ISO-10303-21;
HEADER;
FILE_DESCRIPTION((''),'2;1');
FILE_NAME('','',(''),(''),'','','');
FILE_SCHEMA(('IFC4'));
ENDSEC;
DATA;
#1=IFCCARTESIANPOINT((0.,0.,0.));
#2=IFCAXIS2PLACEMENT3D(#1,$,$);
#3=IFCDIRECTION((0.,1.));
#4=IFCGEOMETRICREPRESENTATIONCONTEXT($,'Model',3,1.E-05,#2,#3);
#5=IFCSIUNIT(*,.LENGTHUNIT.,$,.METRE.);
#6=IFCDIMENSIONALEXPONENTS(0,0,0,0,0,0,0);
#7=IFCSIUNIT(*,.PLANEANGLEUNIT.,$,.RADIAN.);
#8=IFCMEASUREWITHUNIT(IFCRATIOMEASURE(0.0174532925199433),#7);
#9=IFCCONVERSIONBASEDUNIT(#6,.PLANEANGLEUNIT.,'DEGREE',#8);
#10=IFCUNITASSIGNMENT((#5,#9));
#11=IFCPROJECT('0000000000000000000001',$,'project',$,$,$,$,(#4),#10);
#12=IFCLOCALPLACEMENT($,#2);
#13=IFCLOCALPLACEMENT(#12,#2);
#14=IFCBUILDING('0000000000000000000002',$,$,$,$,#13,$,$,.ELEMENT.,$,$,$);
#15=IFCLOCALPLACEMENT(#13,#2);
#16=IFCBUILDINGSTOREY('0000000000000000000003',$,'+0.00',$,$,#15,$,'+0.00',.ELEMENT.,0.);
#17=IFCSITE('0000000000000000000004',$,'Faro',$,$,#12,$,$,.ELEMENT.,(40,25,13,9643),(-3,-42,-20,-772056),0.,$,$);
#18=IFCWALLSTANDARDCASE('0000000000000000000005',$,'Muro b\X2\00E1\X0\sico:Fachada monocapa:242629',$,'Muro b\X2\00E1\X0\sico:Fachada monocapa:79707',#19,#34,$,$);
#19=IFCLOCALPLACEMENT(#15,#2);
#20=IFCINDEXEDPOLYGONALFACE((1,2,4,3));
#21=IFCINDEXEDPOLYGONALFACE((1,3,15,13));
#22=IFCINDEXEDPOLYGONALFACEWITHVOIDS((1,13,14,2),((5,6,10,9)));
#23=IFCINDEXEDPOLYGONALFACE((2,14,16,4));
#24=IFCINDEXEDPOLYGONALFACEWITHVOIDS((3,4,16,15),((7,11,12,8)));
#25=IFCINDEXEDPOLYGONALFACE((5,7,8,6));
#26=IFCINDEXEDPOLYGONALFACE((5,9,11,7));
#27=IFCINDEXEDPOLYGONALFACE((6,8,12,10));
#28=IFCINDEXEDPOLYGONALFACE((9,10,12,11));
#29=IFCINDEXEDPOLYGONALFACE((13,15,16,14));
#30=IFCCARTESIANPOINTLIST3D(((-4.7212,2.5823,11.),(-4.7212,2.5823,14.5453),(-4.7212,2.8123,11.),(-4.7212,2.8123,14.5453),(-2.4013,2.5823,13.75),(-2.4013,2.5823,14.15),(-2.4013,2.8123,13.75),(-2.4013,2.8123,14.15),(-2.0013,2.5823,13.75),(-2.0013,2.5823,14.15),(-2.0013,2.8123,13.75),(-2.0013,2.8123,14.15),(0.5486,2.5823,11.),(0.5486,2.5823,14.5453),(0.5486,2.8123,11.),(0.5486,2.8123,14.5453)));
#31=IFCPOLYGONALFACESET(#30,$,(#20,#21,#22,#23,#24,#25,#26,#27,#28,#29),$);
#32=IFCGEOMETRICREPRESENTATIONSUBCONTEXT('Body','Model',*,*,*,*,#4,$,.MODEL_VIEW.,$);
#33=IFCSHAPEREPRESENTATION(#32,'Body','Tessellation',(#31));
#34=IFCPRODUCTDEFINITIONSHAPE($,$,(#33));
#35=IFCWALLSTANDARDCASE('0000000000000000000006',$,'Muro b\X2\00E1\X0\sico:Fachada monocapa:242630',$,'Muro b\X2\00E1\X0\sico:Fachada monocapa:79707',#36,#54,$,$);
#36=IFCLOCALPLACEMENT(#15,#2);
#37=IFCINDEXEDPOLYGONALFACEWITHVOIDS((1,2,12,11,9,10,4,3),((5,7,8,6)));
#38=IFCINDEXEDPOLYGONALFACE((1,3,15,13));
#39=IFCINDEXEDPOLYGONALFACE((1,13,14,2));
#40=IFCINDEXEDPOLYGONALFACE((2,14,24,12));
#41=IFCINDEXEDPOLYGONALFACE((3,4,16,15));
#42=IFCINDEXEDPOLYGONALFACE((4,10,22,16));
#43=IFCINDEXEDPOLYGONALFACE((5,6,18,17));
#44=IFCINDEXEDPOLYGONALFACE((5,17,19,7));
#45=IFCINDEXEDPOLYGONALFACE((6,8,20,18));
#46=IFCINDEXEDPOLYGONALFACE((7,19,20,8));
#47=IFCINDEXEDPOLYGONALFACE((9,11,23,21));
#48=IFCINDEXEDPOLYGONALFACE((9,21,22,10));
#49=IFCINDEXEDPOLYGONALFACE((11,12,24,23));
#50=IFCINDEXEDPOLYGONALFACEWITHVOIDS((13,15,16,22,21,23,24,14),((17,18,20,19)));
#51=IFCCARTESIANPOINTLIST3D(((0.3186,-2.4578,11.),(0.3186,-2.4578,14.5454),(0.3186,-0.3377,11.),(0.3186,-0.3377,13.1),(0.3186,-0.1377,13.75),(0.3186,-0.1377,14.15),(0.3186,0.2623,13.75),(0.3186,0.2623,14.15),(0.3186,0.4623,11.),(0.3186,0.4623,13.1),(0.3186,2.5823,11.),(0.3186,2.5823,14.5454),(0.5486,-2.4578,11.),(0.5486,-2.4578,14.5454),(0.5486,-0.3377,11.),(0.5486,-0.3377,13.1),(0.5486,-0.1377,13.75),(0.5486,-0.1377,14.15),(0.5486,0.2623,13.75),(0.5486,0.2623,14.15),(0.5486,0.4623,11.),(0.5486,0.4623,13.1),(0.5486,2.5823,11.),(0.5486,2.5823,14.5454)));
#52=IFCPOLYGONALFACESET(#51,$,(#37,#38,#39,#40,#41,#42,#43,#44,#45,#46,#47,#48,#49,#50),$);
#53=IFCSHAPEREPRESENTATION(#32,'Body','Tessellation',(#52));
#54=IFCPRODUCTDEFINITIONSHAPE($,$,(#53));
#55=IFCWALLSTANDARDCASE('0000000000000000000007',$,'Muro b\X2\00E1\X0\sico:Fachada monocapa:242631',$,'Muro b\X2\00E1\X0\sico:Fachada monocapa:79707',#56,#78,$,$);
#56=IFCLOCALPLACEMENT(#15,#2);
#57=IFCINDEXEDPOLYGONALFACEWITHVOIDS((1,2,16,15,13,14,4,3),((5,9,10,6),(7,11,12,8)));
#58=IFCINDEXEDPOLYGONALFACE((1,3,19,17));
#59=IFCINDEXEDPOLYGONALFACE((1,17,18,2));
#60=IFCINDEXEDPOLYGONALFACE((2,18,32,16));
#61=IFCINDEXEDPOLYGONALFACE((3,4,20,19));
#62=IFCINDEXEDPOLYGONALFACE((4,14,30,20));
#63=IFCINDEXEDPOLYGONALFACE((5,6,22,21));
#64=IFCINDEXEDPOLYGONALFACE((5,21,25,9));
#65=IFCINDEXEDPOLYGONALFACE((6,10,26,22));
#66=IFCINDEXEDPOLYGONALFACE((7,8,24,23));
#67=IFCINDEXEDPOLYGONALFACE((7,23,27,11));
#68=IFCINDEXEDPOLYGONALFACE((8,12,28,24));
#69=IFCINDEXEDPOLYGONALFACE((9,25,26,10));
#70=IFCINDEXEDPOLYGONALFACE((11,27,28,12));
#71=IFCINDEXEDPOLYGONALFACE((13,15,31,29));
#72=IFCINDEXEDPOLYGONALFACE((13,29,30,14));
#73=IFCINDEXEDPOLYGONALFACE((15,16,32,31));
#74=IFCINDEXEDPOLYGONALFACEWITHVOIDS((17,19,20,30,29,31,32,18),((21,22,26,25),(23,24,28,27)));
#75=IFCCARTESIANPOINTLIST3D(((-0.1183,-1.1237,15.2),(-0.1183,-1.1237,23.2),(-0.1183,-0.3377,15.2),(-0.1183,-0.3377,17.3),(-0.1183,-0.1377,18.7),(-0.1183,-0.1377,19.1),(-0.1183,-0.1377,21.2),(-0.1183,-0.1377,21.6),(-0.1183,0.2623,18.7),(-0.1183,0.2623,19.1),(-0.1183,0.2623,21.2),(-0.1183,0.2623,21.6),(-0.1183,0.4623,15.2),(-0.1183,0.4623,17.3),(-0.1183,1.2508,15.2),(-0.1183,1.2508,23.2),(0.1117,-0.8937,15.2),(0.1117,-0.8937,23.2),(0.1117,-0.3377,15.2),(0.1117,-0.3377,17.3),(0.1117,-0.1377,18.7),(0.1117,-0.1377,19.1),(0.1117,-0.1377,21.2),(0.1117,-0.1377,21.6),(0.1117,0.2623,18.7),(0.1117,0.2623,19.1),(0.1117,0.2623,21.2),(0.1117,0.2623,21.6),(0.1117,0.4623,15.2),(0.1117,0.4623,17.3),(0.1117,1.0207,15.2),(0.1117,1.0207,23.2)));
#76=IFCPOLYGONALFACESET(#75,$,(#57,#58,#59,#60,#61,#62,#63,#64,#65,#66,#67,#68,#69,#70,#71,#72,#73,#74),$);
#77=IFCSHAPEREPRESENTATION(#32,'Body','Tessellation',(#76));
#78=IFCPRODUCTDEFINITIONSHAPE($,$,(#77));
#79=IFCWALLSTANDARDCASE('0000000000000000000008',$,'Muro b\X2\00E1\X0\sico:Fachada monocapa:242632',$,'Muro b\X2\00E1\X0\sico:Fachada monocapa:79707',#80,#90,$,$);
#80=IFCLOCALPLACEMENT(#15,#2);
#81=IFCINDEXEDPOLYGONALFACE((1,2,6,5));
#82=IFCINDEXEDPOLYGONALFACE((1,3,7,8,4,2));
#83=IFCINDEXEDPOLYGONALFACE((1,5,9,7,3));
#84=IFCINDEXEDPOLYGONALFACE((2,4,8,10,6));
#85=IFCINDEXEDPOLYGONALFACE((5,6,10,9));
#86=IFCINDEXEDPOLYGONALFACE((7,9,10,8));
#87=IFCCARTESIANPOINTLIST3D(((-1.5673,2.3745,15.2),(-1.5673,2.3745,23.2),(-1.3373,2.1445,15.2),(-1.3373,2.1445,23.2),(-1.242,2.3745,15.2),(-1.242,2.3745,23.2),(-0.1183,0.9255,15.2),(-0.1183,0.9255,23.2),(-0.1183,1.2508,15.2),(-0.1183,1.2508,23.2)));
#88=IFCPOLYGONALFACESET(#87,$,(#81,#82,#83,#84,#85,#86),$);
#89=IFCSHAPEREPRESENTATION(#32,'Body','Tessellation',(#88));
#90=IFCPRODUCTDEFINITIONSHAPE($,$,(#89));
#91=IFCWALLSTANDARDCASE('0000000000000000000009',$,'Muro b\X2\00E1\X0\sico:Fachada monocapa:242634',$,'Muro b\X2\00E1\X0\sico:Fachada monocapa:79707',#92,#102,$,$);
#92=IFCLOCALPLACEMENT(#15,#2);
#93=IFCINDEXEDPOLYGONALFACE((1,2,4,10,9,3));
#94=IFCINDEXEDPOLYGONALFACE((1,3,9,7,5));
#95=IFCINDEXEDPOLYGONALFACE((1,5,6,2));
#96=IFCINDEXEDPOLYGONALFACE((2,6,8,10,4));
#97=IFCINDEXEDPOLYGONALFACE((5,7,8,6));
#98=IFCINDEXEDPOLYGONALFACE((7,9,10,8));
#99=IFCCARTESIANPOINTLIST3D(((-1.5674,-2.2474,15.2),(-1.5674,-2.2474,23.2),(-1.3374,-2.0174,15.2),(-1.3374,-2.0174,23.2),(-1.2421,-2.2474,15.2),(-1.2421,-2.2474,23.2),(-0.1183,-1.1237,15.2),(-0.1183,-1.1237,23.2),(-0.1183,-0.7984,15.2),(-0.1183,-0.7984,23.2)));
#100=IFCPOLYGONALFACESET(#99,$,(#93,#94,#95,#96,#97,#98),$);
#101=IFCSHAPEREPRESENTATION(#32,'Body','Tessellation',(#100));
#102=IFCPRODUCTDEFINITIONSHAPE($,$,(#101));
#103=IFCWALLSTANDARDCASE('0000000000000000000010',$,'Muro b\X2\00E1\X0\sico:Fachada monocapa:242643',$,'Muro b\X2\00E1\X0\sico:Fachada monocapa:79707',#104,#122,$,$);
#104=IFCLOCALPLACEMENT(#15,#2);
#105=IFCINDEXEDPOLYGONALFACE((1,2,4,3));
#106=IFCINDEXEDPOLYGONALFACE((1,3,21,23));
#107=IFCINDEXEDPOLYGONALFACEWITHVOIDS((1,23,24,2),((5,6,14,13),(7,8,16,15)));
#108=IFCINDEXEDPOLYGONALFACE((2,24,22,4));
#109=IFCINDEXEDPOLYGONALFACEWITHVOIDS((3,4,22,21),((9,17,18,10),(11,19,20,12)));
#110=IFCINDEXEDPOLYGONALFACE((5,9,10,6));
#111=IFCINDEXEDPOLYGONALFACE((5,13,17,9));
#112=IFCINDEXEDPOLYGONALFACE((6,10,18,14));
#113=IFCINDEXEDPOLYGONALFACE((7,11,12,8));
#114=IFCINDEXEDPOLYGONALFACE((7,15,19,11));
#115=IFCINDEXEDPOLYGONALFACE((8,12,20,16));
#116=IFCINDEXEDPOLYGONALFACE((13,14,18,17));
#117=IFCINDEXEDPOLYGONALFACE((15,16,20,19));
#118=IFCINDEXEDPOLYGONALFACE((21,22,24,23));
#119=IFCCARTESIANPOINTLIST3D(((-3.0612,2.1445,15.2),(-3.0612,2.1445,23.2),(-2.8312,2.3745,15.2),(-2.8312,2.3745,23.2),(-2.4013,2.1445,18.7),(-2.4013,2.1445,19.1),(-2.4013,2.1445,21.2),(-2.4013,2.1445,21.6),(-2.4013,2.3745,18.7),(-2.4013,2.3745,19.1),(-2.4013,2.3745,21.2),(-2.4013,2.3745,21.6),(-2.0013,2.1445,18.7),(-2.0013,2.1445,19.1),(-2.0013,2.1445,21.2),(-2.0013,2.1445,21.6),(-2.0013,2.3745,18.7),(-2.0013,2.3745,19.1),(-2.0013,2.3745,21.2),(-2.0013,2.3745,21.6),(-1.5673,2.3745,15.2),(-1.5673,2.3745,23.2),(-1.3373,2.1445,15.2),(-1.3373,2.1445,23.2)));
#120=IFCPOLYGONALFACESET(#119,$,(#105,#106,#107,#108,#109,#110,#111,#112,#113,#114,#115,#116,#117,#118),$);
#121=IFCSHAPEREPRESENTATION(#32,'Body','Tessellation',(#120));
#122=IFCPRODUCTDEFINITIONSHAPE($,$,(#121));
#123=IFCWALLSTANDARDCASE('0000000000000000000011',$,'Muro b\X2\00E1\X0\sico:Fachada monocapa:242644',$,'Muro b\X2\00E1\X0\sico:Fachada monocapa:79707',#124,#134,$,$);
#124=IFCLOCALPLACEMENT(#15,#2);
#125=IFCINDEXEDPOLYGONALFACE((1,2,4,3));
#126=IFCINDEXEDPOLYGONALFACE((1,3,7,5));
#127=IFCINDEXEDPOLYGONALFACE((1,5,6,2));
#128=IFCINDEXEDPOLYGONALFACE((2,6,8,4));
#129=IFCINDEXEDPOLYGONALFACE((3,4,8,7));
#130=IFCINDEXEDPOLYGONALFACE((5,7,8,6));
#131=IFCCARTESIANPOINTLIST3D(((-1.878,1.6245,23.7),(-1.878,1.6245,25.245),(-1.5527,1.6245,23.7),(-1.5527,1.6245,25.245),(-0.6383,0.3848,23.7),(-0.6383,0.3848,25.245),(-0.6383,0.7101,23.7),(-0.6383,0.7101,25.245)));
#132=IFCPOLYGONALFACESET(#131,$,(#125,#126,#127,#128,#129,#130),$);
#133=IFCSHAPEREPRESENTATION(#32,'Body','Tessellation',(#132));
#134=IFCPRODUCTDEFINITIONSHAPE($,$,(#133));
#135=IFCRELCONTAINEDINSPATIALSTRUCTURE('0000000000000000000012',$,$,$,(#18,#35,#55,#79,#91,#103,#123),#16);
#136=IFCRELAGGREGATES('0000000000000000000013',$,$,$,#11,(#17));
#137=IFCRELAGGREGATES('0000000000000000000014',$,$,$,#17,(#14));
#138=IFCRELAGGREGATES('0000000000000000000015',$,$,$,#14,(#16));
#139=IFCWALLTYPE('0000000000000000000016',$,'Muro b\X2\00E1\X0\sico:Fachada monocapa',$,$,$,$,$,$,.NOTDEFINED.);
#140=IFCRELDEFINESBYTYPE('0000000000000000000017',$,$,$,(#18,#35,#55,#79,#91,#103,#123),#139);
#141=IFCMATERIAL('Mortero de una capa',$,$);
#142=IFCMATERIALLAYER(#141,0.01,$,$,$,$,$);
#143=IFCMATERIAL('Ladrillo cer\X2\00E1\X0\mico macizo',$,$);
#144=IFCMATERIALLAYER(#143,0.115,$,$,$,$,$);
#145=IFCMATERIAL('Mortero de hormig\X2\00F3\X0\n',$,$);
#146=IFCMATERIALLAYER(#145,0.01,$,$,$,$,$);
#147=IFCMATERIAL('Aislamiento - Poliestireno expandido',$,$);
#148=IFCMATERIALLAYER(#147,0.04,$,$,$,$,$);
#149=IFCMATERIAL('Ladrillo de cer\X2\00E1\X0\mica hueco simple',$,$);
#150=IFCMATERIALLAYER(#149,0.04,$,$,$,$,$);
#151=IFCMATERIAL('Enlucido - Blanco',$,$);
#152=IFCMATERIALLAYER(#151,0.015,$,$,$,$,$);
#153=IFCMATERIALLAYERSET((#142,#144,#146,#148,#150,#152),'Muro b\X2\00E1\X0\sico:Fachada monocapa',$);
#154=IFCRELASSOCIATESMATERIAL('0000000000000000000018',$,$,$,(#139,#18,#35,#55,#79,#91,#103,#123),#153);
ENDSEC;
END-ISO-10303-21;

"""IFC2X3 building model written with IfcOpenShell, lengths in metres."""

from ifc_helpers import new_model, entity, si_unit, converted_unit, direction, frame, frame_2d, origin, place, context, subcontext, project, spatial, polyline, rectangle, outline, extrude, clip, bounded_halfspace, material, layer, layer_set, layer_usage, type_object, element, save


model = new_model("IFC2X3")

# Units and contexts
model_context = context("Model", 3, precision=1e-05, world=origin(), true_north=direction((0.0, 1.0)))
body_context = subcontext(model_context, "Body", "Model", "MODEL_VIEW")
ifc_project = project(units=[si_unit("LENGTHUNIT", "METRE"), converted_unit("PLANEANGLEUNIT", "DEGREE", entity("IfcRatioMeasure", 0.0174532925199433), si_unit("PLANEANGLEUNIT", "RADIAN"), dimensions=[0, 0, 0, 0, 0, 0, 0])], contexts=[model_context])

# Site, building, storey
site_placement = place(None, origin())
site = spatial("IfcSite", under=ifc_project, at=site_placement, Name="Faro", CompositionType="ELEMENT", RefLatitude=(40, 25, 13, 9643), RefLongitude=(-3, -42, -20, -772056), RefElevation=0.0)
building_placement = place(site_placement, origin())
building = spatial("IfcBuilding", under=site, at=building_placement, CompositionType="ELEMENT")
storey_placement = place(building_placement, origin())
storey = spatial("IfcBuildingStorey", under=building, at=storey_placement, Name="+0.00", LongName="+0.00", CompositionType="ELEMENT", Elevation=0.0)

# Wall, opening
ifc_material_1 = material(Name="Mortero de una capa")
ifc_layer_1 = layer(ifc_material_1, 0.01)
ifc_material_2 = material(Name="Ladrillo cerámico macizo")
ifc_layer_2 = layer(ifc_material_2, 0.115)
ifc_material_3 = material(Name="Mortero de hormigón")
ifc_layer_3 = layer(ifc_material_3, 0.01)
ifc_material_4 = material(Name="Aislamiento - Poliestireno expandido")
ifc_layer_4 = layer(ifc_material_4, 0.04)
ifc_material_5 = material(Name="Ladrillo de cerámica hueco simple")
ifc_layer_5 = layer(ifc_material_5, 0.04)
ifc_material_6 = material(Name="Enlucido - Blanco")
ifc_layer_6 = layer(ifc_material_6, 0.015)
ifc_layer_set = layer_set([ifc_layer_1, ifc_layer_2, ifc_layer_3, ifc_layer_4, ifc_layer_5, ifc_layer_6], Name="Muro básico:Fachada monocapa")
ifc_layer_usage_1 = layer_usage(ifc_layer_set, "AXIS2", "POSITIVE", -0.115)
wall_type = type_object("IfcWallType", Name="Muro básico:Fachada monocapa", PredefinedType="NOTDEFINED", material=ifc_layer_set)
wall_1_placement = place(storey_placement, frame((0.5486, 2.6973, 11.0), z_axis=(0.0, 0.0, 1.0), x_axis=(-1.0, 0.0, 0.0)))
wall_1 = element("IfcWallStandardCase", 1, at=wall_1_placement, inside=storey, type_object=wall_type, material=ifc_layer_usage_1, Name="Muro básico:Fachada monocapa:242629", ObjectType="Muro básico:Fachada monocapa:79707", context=body_context, shape_type="SweptSolid", body=[
    extrude(rectangle(XDim=5.2698, YDim=0.23, at=frame_2d((2.6349, 0.0), x_axis=(-1.0, 0.0))), origin(), (0.0, 0.0, 1.0), 3.5453),
])
opening_1_placement = place(wall_1_placement, frame((2.9499, 0.115, 2.75)))
element("IfcOpeningElement", 2, at=opening_1_placement, cuts=wall_1, ObjectType="Opening", context=body_context, shape_type="SweptSolid", body=[
    extrude(rectangle(XDim=0.4, YDim=0.4, at=frame_2d((0.2, 0.2), x_axis=(1.0, 0.0))), frame((0.0, 0.0, 0.0), z_axis=(0.0, -1.0, 0.0), x_axis=(0.0, 0.0, 1.0)), (0.0, 0.0, 1.0), 0.23),
])

# Walls, openings
ifc_layer_usage_2 = layer_usage(ifc_layer_set, "AXIS2", "POSITIVE", -0.115)
wall_2_placement = place(storey_placement, frame((0.4336, -2.4578, 11.0), z_axis=(0.0, 0.0, 1.0), x_axis=(0.0, 1.0, 0.0)))
wall_2 = element("IfcWallStandardCase", 3, at=wall_2_placement, inside=storey, type_object=wall_type, material=ifc_layer_usage_2, Name="Muro básico:Fachada monocapa:242630", ObjectType="Muro básico:Fachada monocapa:79707", context=body_context, shape_type="SweptSolid", body=[
    extrude(rectangle(XDim=5.0401, YDim=0.23, at=frame_2d((2.5201, 0.0), x_axis=(-1.0, 0.0))), origin(), (0.0, 0.0, 1.0), 3.5454),
])
opening_2_placement = place(wall_2_placement, frame((2.9201, 0.115, 0.0)))
element("IfcOpeningElement", 4, at=opening_2_placement, cuts=wall_2, ObjectType="Opening", context=body_context, shape_type="SweptSolid", body=[
    extrude(rectangle(XDim=2.1, YDim=0.8, at=frame_2d((1.05, 0.4), x_axis=(1.0, 0.0))), frame((0.0, 0.0, 0.0), z_axis=(0.0, -1.0, 0.0), x_axis=(0.0, 0.0, 1.0)), (0.0, 0.0, 1.0), 0.23),
])
opening_3_placement = place(wall_2_placement, frame((2.7201, 0.115, 2.75)))
element("IfcOpeningElement", 5, at=opening_3_placement, cuts=wall_2, ObjectType="Opening", context=body_context, shape_type="SweptSolid", body=[
    extrude(rectangle(XDim=0.4, YDim=0.4, at=frame_2d((0.2, 0.2), x_axis=(1.0, 0.0))), frame((0.0, 0.0, 0.0), z_axis=(0.0, -1.0, 0.0), x_axis=(0.0, 0.0, 1.0)), (0.0, 0.0, 1.0), 0.23),
])
ifc_layer_usage_3 = layer_usage(ifc_layer_set, "AXIS2", "POSITIVE", -0.115)
wall_3_placement = place(storey_placement, frame((-0.0033, -1.1237, 15.2), z_axis=(0.0, 0.0, 1.0), x_axis=(0.0, 1.0, 0.0)))
wall_3 = element("IfcWallStandardCase", 6, at=wall_3_placement, inside=storey, type_object=wall_type, material=ifc_layer_usage_3, Name="Muro básico:Fachada monocapa:242631", ObjectType="Muro básico:Fachada monocapa:79707", context=body_context, shape_type="SweptSolid", body=[
    extrude(outline(polyline([(0.23, -0.115), (2.1444, -0.115), (2.3744, 0.115), (2.0492, 0.115), (0.3253, 0.115), (0.0, 0.115), (0.23, -0.115)])), origin(), (0.0, 0.0, 1.0), 8.0),
])
opening_4_placement = place(wall_3_placement, frame((1.586, 0.115, 0.0)))
element("IfcOpeningElement", 7, at=opening_4_placement, cuts=wall_3, ObjectType="Opening", context=body_context, shape_type="SweptSolid", body=[
    extrude(rectangle(XDim=2.1, YDim=0.8, at=frame_2d((1.05, 0.4), x_axis=(1.0, 0.0))), frame((0.0, 0.0, 0.0), z_axis=(0.0, -1.0, 0.0), x_axis=(0.0, 0.0, 1.0)), (0.0, 0.0, 1.0), 0.23),
])
opening_5_placement = place(wall_3_placement, frame((1.386, 0.115, 3.5)))
element("IfcOpeningElement", 8, at=opening_5_placement, cuts=wall_3, ObjectType="Opening", context=body_context, shape_type="SweptSolid", body=[
    extrude(rectangle(XDim=0.4, YDim=0.4, at=frame_2d((0.2, 0.2), x_axis=(1.0, 0.0))), frame((0.0, 0.0, 0.0), z_axis=(0.0, -1.0, 0.0), x_axis=(0.0, 0.0, 1.0)), (0.0, 0.0, 1.0), 0.23),
])
opening_6_placement = place(wall_3_placement, frame((1.386, 0.115, 6.0)))
element("IfcOpeningElement", 9, at=opening_6_placement, cuts=wall_3, ObjectType="Opening", context=body_context, shape_type="SweptSolid", body=[
    extrude(rectangle(XDim=0.4, YDim=0.4, at=frame_2d((0.2, 0.2), x_axis=(1.0, 0.0))), frame((0.0, 0.0, 0.0), z_axis=(0.0, -1.0, 0.0), x_axis=(0.0, 0.0, 1.0)), (0.0, 0.0, 1.0), 0.23),
])

# Walls
ifc_layer_usage_4 = layer_usage(ifc_layer_set, "AXIS2", "POSITIVE", -0.115)
wall_4_placement = place(storey_placement, frame((-0.037, 1.0068, 15.2), z_axis=(0.0, 0.0, 1.0), x_axis=(-0.707093, 0.707121, 0.0)))
element("IfcWallStandardCase", 10, at=wall_4_placement, inside=storey, type_object=wall_type, material=ifc_layer_usage_4, Name="Muro básico:Fachada monocapa:242632", ObjectType="Muro básico:Fachada monocapa:79707", context=body_context, shape_type="SweptSolid", body=[
    extrude(outline(polyline([(1.8192, -0.115), (2.0492, 0.115), (1.7239, 0.115), (0.0, 0.115), (0.23, -0.115), (1.8192, -0.115)])), origin(), (0.0, 0.0, 1.0), 8.0),
])
ifc_layer_usage_5 = layer_usage(ifc_layer_set, "AXIS2", "POSITIVE", -0.115)
wall_5_placement = place(storey_placement, frame((-1.486, -2.3287, 15.2), z_axis=(0.0, 0.0, 1.0), x_axis=(0.707121, 0.707093, 0.0)))
element("IfcWallStandardCase", 11, at=wall_5_placement, inside=storey, type_object=wall_type, material=ifc_layer_usage_5, Name="Muro básico:Fachada monocapa:242634", ObjectType="Muro básico:Fachada monocapa:79707", context=body_context, shape_type="SweptSolid", body=[
    extrude(outline(polyline([(1.8192, -0.115), (2.0492, 0.115), (0.3253, 0.115), (0.0, 0.115), (0.23, -0.115), (1.8192, -0.115)])), origin(), (0.0, 0.0, 1.0), 8.0),
])

# Wall, openings
ifc_layer_usage_6 = layer_usage(ifc_layer_set, "AXIS2", "POSITIVE", -0.115)
wall_6_placement = place(storey_placement, frame((-1.3373, 2.2595, 15.2), z_axis=(0.0, 0.0, 1.0), x_axis=(-1.0, 0.0, 0.0)))
wall_6 = element("IfcWallStandardCase", 12, at=wall_6_placement, inside=storey, type_object=wall_type, material=ifc_layer_usage_6, Name="Muro básico:Fachada monocapa:242643", ObjectType="Muro básico:Fachada monocapa:79707", context=body_context, shape_type="SweptSolid", body=[
    extrude(outline(polyline([(1.4939, -0.115), (1.7239, 0.115), (0.0, 0.115), (0.23, -0.115), (1.4939, -0.115)])), origin(), (0.0, 0.0, 1.0), 8.0),
])
opening_7_placement = place(wall_6_placement, frame((1.064, 0.115, 3.5)))
element("IfcOpeningElement", 13, at=opening_7_placement, cuts=wall_6, ObjectType="Opening", context=body_context, shape_type="SweptSolid", body=[
    extrude(rectangle(XDim=0.4, YDim=0.4, at=frame_2d((0.2, 0.2), x_axis=(1.0, 0.0))), frame((0.0, 0.0, 0.0), z_axis=(0.0, -1.0, 0.0), x_axis=(0.0, 0.0, 1.0)), (0.0, 0.0, 1.0), 0.23),
])
opening_8_placement = place(wall_6_placement, frame((1.064, 0.115, 6.0)))
element("IfcOpeningElement", 14, at=opening_8_placement, cuts=wall_6, ObjectType="Opening", context=body_context, shape_type="SweptSolid", body=[
    extrude(rectangle(XDim=0.4, YDim=0.4, at=frame_2d((0.2, 0.2), x_axis=(1.0, 0.0))), frame((0.0, 0.0, 0.0), z_axis=(0.0, -1.0, 0.0), x_axis=(0.0, 0.0, 1.0)), (0.0, 0.0, 1.0), 0.23),
])

# Wall
ifc_layer_usage_7 = layer_usage(ifc_layer_set, "AXIS2", "POSITIVE", -0.115)
wall_7_placement = place(storey_placement, frame((-0.557, 0.4661, 23.7), z_axis=(0.0, 0.0, 1.0), x_axis=(-0.707093, 0.707121, 0.0)))
element("IfcWallStandardCase", 15, at=wall_7_placement, inside=storey, type_object=wall_type, material=ifc_layer_usage_7, Name="Muro básico:Fachada monocapa:242644", ObjectType="Muro básico:Fachada monocapa:79707", context=body_context, shape_type="Clipping", body=[
    clip(extrude(outline(polyline([(1.5231, -0.115), (1.7531, 0.115), (1.4279, 0.115), (0.3253, 0.115), (0.0, 0.115), (0.23, -0.115), (1.5231, -0.115)])), origin(), (0.0, 0.0, 1.0), 1.545), bounded_halfspace(frame((0.23, -0.115, 1.545), z_axis=(0.0, 0.0, 1.0), x_axis=(0.707093, 0.707121, 0.0)), False, frame((0.23, -0.115, 1.545), z_axis=(0.0, 0.0, 1.0), x_axis=(0.707093, 0.707121, 0.0)), polyline([(0.0, 0.0), (0.9144, -0.9144), (1.2396, -0.9144), (1.0096, -0.6844), (0.23, 0.0953), (0.0, 0.3253), (0.0, 0.0)]))),
])

save(model, "model.ifc")
